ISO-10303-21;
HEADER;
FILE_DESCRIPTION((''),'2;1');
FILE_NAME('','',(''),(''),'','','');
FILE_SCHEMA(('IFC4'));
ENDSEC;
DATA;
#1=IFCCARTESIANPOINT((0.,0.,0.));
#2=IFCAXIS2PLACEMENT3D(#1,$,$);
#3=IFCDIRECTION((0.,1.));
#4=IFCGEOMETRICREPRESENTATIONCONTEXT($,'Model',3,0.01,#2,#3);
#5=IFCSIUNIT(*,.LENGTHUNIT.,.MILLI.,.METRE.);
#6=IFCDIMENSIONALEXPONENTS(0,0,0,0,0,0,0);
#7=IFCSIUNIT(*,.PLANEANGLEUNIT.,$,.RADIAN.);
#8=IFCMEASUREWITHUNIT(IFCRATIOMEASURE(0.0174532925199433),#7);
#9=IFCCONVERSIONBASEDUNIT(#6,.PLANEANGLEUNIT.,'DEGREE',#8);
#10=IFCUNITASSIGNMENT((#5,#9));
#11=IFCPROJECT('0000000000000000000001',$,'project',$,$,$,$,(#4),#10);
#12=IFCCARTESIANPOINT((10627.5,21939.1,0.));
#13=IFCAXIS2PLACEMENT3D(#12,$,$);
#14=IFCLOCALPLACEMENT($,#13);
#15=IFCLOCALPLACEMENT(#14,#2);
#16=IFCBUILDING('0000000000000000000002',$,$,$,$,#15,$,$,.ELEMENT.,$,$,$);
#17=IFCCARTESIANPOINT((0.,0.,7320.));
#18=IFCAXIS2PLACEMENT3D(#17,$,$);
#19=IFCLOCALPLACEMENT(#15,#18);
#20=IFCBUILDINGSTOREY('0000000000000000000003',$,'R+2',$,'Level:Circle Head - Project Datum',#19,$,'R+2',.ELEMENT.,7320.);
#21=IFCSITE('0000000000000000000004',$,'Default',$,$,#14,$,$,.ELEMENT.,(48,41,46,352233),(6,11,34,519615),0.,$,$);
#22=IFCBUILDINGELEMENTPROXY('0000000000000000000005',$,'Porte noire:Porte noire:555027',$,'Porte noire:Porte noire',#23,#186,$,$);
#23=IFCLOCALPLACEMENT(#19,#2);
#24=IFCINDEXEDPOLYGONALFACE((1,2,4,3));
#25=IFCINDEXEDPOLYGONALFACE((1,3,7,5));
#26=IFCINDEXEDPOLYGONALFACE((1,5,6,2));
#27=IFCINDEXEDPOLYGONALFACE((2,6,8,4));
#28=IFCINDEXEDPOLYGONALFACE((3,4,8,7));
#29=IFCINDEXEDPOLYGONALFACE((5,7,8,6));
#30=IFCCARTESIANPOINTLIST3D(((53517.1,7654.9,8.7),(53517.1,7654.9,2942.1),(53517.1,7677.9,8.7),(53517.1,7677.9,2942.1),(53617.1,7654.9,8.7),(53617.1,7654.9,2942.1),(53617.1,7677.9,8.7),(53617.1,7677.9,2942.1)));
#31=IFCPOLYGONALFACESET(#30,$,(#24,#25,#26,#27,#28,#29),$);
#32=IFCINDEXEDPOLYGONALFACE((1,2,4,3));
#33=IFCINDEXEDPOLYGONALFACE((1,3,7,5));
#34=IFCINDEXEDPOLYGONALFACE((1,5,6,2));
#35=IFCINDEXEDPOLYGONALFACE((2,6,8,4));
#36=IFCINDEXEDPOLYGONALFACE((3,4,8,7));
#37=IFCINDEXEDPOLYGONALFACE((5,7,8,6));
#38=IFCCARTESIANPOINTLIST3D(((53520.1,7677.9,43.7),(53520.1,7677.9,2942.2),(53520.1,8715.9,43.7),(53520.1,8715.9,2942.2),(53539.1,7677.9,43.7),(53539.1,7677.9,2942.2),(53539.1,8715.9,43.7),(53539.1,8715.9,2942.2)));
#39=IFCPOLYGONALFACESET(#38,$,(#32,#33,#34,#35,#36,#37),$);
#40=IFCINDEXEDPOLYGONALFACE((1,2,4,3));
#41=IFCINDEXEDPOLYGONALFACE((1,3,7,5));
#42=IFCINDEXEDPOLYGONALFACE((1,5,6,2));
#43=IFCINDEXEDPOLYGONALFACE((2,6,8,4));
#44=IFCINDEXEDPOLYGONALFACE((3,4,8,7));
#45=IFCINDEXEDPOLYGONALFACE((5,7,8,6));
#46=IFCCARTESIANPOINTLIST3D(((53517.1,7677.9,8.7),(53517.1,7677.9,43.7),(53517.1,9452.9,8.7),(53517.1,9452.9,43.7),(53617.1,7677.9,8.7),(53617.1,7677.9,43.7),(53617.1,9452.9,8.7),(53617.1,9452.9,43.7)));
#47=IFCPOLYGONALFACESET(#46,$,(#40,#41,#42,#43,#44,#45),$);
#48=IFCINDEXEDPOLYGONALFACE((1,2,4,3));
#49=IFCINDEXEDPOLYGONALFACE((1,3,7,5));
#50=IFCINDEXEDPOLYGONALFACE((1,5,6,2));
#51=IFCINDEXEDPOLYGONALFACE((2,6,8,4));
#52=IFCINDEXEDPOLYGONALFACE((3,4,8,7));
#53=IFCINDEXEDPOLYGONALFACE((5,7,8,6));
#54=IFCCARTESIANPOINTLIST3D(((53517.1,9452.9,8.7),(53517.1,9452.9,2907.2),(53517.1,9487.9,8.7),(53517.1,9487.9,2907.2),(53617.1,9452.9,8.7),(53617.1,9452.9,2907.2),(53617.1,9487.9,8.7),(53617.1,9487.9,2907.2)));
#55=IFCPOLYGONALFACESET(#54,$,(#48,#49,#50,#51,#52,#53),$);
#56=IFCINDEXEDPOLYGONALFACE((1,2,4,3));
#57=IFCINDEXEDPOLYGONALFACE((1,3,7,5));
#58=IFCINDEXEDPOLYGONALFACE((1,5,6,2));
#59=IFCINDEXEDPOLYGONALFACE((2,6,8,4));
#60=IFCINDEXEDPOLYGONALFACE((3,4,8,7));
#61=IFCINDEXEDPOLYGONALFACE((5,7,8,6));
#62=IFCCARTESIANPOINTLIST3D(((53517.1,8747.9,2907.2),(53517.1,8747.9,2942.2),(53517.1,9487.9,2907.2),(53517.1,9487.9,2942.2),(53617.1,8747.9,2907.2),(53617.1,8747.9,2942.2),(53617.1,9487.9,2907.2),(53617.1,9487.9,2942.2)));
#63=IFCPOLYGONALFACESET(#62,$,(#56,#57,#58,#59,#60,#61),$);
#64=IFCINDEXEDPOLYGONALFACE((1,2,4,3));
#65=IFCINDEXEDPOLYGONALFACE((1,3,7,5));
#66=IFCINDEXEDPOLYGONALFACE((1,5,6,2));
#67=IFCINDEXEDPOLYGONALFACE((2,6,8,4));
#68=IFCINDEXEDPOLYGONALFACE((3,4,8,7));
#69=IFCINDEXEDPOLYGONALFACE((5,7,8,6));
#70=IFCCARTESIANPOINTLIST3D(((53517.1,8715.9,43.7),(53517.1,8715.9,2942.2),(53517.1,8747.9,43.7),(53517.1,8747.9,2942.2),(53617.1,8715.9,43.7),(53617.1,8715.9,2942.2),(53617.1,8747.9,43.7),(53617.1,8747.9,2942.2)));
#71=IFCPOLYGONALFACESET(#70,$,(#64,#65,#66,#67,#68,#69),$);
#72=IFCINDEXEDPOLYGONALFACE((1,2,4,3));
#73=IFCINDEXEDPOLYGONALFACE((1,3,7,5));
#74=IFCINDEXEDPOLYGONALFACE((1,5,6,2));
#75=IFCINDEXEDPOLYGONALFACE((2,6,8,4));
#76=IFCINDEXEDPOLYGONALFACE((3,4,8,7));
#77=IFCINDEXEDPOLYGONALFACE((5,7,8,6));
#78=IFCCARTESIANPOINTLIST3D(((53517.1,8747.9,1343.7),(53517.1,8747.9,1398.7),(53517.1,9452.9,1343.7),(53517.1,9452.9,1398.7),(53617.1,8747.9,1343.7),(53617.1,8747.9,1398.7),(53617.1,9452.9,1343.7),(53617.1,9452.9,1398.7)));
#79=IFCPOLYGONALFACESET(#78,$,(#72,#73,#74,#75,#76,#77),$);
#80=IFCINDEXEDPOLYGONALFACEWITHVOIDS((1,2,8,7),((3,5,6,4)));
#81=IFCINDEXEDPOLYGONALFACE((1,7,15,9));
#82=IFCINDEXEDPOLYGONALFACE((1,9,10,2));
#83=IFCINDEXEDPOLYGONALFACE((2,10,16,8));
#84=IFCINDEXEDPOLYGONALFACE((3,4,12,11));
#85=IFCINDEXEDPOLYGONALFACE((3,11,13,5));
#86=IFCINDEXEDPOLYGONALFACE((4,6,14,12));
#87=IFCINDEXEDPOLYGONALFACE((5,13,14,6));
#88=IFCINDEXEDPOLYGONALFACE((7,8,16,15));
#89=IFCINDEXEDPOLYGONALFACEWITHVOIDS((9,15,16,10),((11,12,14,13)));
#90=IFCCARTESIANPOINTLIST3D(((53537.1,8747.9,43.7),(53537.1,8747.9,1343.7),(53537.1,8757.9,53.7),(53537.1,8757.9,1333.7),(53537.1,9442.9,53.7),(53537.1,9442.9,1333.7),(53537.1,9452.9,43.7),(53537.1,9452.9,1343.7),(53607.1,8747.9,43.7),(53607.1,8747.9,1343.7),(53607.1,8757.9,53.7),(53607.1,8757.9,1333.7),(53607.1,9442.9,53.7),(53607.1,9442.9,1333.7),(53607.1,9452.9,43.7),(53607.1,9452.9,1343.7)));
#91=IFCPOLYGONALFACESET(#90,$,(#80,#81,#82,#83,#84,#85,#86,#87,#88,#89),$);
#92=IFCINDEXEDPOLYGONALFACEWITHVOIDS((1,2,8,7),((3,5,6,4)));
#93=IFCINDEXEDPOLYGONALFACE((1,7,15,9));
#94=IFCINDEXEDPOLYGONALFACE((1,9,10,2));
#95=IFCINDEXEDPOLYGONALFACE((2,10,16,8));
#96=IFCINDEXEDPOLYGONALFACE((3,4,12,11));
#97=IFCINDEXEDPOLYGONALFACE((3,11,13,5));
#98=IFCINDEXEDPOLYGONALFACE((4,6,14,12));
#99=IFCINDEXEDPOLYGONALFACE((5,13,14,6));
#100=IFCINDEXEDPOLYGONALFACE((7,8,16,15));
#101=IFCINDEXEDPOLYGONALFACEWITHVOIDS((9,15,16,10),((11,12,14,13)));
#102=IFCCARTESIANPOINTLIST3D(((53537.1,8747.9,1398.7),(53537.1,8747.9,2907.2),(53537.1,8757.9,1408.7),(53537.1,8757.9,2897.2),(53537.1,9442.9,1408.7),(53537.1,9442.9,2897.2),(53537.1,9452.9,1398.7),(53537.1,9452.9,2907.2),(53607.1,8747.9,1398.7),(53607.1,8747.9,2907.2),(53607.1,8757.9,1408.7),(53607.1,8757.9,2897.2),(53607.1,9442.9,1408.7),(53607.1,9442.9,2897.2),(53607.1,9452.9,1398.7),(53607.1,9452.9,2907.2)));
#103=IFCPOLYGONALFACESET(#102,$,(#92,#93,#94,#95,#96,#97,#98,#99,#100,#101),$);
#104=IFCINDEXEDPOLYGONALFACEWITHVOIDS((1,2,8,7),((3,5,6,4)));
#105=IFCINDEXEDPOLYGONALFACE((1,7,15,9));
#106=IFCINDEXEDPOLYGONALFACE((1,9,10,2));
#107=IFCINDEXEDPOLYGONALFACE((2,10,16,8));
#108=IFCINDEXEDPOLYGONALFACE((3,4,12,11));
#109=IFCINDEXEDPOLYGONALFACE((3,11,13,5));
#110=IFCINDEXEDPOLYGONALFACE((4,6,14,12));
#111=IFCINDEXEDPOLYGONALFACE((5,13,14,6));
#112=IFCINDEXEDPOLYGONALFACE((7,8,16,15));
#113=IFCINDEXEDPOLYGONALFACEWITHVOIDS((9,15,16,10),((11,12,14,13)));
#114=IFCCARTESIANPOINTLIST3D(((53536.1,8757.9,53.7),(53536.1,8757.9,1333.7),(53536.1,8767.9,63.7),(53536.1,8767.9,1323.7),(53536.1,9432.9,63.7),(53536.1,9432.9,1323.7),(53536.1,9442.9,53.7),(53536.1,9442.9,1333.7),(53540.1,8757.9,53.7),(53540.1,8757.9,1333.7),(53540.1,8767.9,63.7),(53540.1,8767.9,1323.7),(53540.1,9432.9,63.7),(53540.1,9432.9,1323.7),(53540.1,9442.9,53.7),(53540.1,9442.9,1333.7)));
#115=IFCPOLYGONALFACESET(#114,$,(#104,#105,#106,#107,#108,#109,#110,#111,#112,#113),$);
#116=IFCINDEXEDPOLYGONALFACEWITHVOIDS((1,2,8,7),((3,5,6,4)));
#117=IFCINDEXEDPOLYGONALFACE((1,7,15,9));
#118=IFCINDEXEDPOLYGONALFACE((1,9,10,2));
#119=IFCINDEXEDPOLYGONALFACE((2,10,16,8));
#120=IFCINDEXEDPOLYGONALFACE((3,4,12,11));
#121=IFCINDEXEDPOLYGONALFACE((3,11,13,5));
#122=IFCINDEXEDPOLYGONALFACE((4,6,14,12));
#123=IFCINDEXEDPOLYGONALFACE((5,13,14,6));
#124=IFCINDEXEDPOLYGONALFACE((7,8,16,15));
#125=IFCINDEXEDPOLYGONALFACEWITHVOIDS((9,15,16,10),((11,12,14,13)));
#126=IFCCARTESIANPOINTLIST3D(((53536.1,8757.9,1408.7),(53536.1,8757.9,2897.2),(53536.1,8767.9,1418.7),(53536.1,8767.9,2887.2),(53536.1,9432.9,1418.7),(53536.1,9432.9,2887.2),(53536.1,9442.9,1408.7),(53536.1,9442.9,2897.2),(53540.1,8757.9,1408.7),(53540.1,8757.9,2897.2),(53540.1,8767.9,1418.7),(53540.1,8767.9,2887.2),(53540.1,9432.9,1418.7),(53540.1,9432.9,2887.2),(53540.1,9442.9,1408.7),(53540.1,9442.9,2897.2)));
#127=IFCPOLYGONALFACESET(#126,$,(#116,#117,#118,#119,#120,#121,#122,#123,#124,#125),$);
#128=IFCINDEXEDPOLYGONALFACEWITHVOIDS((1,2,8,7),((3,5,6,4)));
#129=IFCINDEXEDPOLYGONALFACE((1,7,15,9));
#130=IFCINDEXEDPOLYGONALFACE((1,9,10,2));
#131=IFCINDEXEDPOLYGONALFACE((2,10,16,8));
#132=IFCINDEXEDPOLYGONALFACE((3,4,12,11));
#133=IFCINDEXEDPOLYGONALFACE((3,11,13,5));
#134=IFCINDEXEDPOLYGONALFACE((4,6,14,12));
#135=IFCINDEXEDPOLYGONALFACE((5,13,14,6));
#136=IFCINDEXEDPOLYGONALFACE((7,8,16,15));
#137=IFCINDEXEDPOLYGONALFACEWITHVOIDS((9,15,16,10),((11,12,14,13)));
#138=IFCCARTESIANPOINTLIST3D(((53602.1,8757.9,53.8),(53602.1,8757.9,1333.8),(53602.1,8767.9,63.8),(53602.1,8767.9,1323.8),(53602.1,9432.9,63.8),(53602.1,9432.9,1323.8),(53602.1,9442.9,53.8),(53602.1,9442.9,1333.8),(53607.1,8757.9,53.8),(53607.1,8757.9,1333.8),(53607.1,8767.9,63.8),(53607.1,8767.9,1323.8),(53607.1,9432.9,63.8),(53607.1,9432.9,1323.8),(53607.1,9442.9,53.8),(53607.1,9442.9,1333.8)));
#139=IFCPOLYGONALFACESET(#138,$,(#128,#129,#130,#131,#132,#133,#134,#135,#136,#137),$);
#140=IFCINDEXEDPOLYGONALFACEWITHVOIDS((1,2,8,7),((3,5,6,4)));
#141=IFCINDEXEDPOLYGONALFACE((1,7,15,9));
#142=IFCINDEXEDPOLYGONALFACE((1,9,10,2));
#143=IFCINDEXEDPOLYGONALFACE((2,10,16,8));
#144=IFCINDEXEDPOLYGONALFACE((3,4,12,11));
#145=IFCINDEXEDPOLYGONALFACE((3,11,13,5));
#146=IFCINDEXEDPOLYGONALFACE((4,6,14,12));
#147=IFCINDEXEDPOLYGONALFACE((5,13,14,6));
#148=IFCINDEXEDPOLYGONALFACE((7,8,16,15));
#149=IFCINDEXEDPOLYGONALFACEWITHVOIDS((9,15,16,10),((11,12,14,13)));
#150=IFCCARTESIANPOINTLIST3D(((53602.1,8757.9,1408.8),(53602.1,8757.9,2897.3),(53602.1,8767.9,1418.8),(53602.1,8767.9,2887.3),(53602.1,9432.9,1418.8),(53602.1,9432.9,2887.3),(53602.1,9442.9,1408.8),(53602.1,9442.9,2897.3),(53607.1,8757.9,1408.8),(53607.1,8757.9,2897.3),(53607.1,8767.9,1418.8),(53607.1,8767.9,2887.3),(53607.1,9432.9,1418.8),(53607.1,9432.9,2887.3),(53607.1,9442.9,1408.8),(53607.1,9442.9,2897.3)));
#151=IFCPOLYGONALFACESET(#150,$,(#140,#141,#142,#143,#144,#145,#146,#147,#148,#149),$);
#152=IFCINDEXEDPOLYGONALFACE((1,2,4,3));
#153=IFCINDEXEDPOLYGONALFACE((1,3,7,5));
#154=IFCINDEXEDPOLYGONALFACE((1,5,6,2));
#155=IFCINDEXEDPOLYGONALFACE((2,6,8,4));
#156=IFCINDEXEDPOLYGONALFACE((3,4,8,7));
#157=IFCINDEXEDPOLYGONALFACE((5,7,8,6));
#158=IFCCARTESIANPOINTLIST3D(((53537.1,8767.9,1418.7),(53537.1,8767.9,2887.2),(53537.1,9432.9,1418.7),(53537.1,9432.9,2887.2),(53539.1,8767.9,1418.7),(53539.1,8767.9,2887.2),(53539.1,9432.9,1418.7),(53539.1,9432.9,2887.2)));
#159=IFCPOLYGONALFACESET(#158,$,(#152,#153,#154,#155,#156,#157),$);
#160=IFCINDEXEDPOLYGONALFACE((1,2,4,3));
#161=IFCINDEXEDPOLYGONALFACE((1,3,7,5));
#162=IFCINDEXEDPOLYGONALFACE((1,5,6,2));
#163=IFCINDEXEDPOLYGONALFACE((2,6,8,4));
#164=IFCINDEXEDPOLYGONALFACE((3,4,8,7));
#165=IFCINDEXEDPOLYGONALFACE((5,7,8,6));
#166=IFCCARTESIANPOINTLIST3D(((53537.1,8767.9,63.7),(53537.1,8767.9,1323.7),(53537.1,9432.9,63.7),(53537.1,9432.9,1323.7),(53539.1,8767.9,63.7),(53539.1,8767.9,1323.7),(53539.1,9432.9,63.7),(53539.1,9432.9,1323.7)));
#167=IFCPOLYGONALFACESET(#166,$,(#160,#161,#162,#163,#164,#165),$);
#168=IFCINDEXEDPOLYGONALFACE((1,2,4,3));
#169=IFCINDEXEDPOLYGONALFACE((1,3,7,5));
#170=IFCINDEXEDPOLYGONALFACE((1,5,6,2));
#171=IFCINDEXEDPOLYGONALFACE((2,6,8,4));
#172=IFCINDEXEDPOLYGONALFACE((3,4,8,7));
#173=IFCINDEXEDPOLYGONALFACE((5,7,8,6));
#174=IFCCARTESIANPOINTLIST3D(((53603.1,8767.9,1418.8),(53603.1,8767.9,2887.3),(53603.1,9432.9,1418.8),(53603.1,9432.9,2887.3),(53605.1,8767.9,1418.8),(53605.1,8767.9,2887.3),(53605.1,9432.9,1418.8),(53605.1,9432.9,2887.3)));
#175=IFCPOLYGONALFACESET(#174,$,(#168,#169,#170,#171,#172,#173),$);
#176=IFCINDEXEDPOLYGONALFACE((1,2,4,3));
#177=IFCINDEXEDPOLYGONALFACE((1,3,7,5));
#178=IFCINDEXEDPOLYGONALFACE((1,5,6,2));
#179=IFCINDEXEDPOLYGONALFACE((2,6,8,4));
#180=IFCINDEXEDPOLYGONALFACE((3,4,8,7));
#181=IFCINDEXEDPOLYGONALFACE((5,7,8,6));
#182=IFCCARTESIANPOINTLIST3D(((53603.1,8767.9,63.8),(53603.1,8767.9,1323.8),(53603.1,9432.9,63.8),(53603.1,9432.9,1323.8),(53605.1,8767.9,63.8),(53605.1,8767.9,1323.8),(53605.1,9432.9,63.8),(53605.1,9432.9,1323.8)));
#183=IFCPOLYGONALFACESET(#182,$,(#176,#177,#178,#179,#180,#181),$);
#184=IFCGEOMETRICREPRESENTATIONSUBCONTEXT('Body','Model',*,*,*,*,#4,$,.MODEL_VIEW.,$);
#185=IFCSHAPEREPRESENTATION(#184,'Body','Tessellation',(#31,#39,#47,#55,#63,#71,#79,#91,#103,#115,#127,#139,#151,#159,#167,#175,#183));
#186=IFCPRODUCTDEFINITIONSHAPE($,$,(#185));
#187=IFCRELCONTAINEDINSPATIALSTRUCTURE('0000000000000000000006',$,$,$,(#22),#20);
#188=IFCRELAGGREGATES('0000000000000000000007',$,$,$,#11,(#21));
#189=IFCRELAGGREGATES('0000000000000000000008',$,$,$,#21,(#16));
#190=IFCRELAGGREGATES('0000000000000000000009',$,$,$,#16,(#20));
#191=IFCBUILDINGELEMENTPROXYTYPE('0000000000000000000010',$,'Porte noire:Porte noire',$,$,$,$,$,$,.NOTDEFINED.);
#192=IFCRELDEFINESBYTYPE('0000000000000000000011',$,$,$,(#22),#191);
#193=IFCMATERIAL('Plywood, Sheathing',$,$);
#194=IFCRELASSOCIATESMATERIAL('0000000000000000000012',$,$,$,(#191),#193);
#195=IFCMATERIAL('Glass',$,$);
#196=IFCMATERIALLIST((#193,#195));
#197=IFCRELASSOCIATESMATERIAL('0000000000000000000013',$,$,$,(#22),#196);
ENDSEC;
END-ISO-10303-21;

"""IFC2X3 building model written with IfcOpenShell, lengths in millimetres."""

from ifc_helpers import new_model, entity, si_unit, converted_unit, direction, frame, frame_2d, origin, origin_2d_with_axis, place, context, subcontext, project, spatial, polyline, rectangle, outline, extrude, source, transform, mapped, material, material_list, type_object, type_shapes, element, save


model = new_model("IFC2X3")

# Units and contexts
model_context = context("Model", 3, precision=0.01, world=origin(), true_north=direction((0.0, 1.0)))
body_context = subcontext(model_context, "Body", "Model", "MODEL_VIEW")
ifc_project = project(units=[si_unit("LENGTHUNIT", "METRE", prefix="MILLI"), converted_unit("PLANEANGLEUNIT", "DEGREE", entity("IfcRatioMeasure", 0.0174532925199433), si_unit("PLANEANGLEUNIT", "RADIAN"), dimensions=[0, 0, 0, 0, 0, 0, 0])], contexts=[model_context])

# Site, building, storey
site_placement = place(None, frame((10627.5, 21939.1, 0.0)))
site = spatial("IfcSite", under=ifc_project, at=site_placement, Name="Default", CompositionType="ELEMENT", RefLatitude=(48, 41, 46, 352233), RefLongitude=(6, 11, 34, 519615), RefElevation=0.0)
building_placement = place(site_placement, origin())
building = spatial("IfcBuilding", under=site, at=building_placement, CompositionType="ELEMENT")
storey_placement = place(building_placement, frame((0.0, 0.0, 7320.0)))
storey = spatial("IfcBuildingStorey", under=building, at=storey_placement, Name="R+2", ObjectType="Level:Circle Head - Project Datum", LongName="R+2", CompositionType="ELEMENT", Elevation=7320.0)

# Building element proxy
ifc_material_1 = material(Name="Glass")
ifc_material_2 = material(Name="Plywood, Sheathing")
building_element_proxy_type_1 = type_object("IfcBuildingElementProxyType", Name="Porte noire:Porte noire", PredefinedType="NOTDEFINED", material=ifc_material_2)
shared_shape_1 = source(origin(), body_context, "Body", "SweptSolid", [
    extrude(rectangle(XDim=23.0, YDim=100.0, at=frame_2d((0.0, 0.0), x_axis=(1.0, 0.0))), frame((-950.9, 50.0, 8.7), z_axis=(0.0, 0.0, 1.0), x_axis=(-1.0, 0.0, 0.0)), (0.0, 0.0, 1.0), 2933.3),
    extrude(rectangle(XDim=1038.0, YDim=19.0, at=frame_2d((0.0, 0.0), x_axis=(1.0, 0.0))), frame((-420.4, 87.5, 43.7), z_axis=(0.0, 0.0, 1.0), x_axis=(-1.0, 0.0, 0.0)), (0.0, 0.0, 1.0), 2898.5),
    extrude(rectangle(XDim=1775.0, YDim=100.0, at=origin_2d_with_axis()), frame((-51.9, 50.0, 8.7), z_axis=(0.0, 0.0, 1.0), x_axis=(-1.0, 0.0, 0.0)), (0.0, 0.0, 1.0), 35.0),
    extrude(rectangle(XDim=35.0, YDim=100.0, at=origin_2d_with_axis()), frame((853.1, 50.0, 8.7), z_axis=(0.0, 0.0, 1.0), x_axis=(-1.0, 0.0, 0.0)), (0.0, 0.0, 1.0), 2898.5),
    extrude(rectangle(XDim=740.0, YDim=100.0, at=origin_2d_with_axis()), frame((500.6, 50.0, 2907.2), z_axis=(0.0, 0.0, 1.0), x_axis=(-1.0, 0.0, 0.0)), (0.0, 0.0, 1.0), 35.0),
    extrude(rectangle(XDim=32.0, YDim=100.0, at=origin_2d_with_axis()), frame((114.6, 50.0, 43.7), z_axis=(0.0, 0.0, 1.0), x_axis=(-1.0, 0.0, 0.0)), (0.0, 0.0, 1.0), 2898.5),
    extrude(rectangle(XDim=705.0, YDim=100.0, at=origin_2d_with_axis()), frame((483.1, 50.0, 1343.7), z_axis=(0.0, 0.0, 1.0), x_axis=(-1.0, 0.0, 0.0)), (0.0, 0.0, 1.0), 55.0),
    extrude(outline(polyline([(-352.5, -650.0), (352.5, -650.0), (352.5, 650.0), (-352.5, 650.0), (-352.5, -650.0)]), holes=[polyline([(342.5, 640.0), (342.5, -640.0), (-342.5, -640.0), (-342.5, 640.0), (342.5, 640.0)])]), frame((483.1, 10.0, 693.7), z_axis=(0.0, 1.0, 0.0), x_axis=(1.0, 0.0, 0.0)), (0.0, 0.0, 1.0), 70.0),
    extrude(outline(polyline([(-754.2, -352.5), (754.2, -352.5), (754.2, 352.5), (-754.2, 352.5), (-754.2, -352.5)]), holes=[polyline([(744.2, 342.5), (744.2, -342.5), (-744.2, -342.5), (-744.2, 342.5), (744.2, 342.5)])]), frame((483.1, 10.0, 2153.0), z_axis=(0.0, 1.0, 0.0), x_axis=(0.0, 0.0, 1.0)), (0.0, 0.0, 1.0), 70.0),
    extrude(outline(polyline([(-640.0, -342.5), (640.0, -342.5), (640.0, 342.5), (-640.0, 342.5), (-640.0, -342.5)]), holes=[polyline([(630.0, 332.5), (630.0, -332.5), (-630.0, -332.5), (-630.0, 332.5), (630.0, 332.5)])]), frame((483.1, 77.0, 693.7), z_axis=(0.0, 1.0, 0.0), x_axis=(0.0, 0.0, 1.0)), (0.0, 0.0, 1.0), 4.0),
    extrude(outline(polyline([(-744.2, -342.5), (744.2, -342.5), (744.2, 342.5), (-744.2, 342.5), (-744.2, -342.5)]), holes=[polyline([(734.2, 332.5), (734.2, -332.5), (-734.2, -332.5), (-734.2, 332.5), (734.2, 332.5)])]), frame((483.1, 77.0, 2153.0), z_axis=(0.0, 1.0, 0.0), x_axis=(0.0, 0.0, 1.0)), (0.0, 0.0, 1.0), 4.0),
    extrude(outline(polyline([(-640.0, -342.5), (640.0, -342.5), (640.0, 342.5), (-640.0, 342.5), (-640.0, -342.5)]), holes=[polyline([(630.0, 332.5), (630.0, -332.5), (-630.0, -332.5), (-630.0, 332.5), (630.0, 332.5)])]), frame((483.1, 10.0, 693.8), z_axis=(0.0, 1.0, 0.0), x_axis=(0.0, 0.0, 1.0)), (0.0, 0.0, 1.0), 5.0),
    extrude(outline(polyline([(-744.2, -342.5), (744.2, -342.5), (744.2, 342.5), (-744.2, 342.5), (-744.2, -342.5)]), holes=[polyline([(734.2, 332.5), (734.2, -332.5), (-734.2, -332.5), (-734.2, 332.5), (734.2, 332.5)])]), frame((483.1, 10.0, 2153.0), z_axis=(0.0, 1.0, 0.0), x_axis=(0.0, 0.0, 1.0)), (0.0, 0.0, 1.0), 5.0),
    extrude(rectangle(XDim=665.0, YDim=2.0, at=frame_2d((0.0, 0.0), x_axis=(1.0, 0.0))), frame((483.1, 79.0, 1418.7), z_axis=(0.0, 0.0, 1.0), x_axis=(-1.0, 0.0, 0.0)), (0.0, 0.0, 1.0), 1468.5),
    extrude(rectangle(XDim=665.0, YDim=2.0, at=frame_2d((0.0, 0.0), x_axis=(1.0, 0.0))), frame((483.1, 79.0, 63.7), z_axis=(0.0, 0.0, 1.0), x_axis=(-1.0, 0.0, 0.0)), (0.0, 0.0, 1.0), 1260.0),
    extrude(rectangle(XDim=665.0, YDim=2.0, at=frame_2d((0.0, 0.0), x_axis=(1.0, 0.0))), frame((483.1, 13.0, 1418.8), z_axis=(0.0, 0.0, 1.0), x_axis=(-1.0, 0.0, 0.0)), (0.0, 0.0, 1.0), 1468.5),
    extrude(rectangle(XDim=665.0, YDim=2.0, at=frame_2d((0.0, 0.0), x_axis=(1.0, 0.0))), frame((483.1, 13.0, 63.8), z_axis=(0.0, 0.0, 1.0), x_axis=(-1.0, 0.0, 0.0)), (0.0, 0.0, 1.0), 1260.0),
])
type_shapes(building_element_proxy_type_1, [shared_shape_1])
ifc_material_list_1 = material_list([ifc_material_2, ifc_material_1])
proxy_1_placement = place(storey_placement, frame((53617.1, 8617.3, 0.0), z_axis=(0.0, 0.0, 1.0), x_axis=(0.0, 1.0, 0.0)))
element("IfcBuildingElementProxy", 1, at=proxy_1_placement, inside=storey, type_object=building_element_proxy_type_1, material=ifc_material_list_1, Name="Porte noire:Porte noire:555027", ObjectType="Porte noire:Porte noire", context=body_context, shape_type="MappedRepresentation", body=[
    mapped(shared_shape_1, transform((0.0, 0.0, 0.0), scale=1.0)),
])

save(model, "model.ifc")
